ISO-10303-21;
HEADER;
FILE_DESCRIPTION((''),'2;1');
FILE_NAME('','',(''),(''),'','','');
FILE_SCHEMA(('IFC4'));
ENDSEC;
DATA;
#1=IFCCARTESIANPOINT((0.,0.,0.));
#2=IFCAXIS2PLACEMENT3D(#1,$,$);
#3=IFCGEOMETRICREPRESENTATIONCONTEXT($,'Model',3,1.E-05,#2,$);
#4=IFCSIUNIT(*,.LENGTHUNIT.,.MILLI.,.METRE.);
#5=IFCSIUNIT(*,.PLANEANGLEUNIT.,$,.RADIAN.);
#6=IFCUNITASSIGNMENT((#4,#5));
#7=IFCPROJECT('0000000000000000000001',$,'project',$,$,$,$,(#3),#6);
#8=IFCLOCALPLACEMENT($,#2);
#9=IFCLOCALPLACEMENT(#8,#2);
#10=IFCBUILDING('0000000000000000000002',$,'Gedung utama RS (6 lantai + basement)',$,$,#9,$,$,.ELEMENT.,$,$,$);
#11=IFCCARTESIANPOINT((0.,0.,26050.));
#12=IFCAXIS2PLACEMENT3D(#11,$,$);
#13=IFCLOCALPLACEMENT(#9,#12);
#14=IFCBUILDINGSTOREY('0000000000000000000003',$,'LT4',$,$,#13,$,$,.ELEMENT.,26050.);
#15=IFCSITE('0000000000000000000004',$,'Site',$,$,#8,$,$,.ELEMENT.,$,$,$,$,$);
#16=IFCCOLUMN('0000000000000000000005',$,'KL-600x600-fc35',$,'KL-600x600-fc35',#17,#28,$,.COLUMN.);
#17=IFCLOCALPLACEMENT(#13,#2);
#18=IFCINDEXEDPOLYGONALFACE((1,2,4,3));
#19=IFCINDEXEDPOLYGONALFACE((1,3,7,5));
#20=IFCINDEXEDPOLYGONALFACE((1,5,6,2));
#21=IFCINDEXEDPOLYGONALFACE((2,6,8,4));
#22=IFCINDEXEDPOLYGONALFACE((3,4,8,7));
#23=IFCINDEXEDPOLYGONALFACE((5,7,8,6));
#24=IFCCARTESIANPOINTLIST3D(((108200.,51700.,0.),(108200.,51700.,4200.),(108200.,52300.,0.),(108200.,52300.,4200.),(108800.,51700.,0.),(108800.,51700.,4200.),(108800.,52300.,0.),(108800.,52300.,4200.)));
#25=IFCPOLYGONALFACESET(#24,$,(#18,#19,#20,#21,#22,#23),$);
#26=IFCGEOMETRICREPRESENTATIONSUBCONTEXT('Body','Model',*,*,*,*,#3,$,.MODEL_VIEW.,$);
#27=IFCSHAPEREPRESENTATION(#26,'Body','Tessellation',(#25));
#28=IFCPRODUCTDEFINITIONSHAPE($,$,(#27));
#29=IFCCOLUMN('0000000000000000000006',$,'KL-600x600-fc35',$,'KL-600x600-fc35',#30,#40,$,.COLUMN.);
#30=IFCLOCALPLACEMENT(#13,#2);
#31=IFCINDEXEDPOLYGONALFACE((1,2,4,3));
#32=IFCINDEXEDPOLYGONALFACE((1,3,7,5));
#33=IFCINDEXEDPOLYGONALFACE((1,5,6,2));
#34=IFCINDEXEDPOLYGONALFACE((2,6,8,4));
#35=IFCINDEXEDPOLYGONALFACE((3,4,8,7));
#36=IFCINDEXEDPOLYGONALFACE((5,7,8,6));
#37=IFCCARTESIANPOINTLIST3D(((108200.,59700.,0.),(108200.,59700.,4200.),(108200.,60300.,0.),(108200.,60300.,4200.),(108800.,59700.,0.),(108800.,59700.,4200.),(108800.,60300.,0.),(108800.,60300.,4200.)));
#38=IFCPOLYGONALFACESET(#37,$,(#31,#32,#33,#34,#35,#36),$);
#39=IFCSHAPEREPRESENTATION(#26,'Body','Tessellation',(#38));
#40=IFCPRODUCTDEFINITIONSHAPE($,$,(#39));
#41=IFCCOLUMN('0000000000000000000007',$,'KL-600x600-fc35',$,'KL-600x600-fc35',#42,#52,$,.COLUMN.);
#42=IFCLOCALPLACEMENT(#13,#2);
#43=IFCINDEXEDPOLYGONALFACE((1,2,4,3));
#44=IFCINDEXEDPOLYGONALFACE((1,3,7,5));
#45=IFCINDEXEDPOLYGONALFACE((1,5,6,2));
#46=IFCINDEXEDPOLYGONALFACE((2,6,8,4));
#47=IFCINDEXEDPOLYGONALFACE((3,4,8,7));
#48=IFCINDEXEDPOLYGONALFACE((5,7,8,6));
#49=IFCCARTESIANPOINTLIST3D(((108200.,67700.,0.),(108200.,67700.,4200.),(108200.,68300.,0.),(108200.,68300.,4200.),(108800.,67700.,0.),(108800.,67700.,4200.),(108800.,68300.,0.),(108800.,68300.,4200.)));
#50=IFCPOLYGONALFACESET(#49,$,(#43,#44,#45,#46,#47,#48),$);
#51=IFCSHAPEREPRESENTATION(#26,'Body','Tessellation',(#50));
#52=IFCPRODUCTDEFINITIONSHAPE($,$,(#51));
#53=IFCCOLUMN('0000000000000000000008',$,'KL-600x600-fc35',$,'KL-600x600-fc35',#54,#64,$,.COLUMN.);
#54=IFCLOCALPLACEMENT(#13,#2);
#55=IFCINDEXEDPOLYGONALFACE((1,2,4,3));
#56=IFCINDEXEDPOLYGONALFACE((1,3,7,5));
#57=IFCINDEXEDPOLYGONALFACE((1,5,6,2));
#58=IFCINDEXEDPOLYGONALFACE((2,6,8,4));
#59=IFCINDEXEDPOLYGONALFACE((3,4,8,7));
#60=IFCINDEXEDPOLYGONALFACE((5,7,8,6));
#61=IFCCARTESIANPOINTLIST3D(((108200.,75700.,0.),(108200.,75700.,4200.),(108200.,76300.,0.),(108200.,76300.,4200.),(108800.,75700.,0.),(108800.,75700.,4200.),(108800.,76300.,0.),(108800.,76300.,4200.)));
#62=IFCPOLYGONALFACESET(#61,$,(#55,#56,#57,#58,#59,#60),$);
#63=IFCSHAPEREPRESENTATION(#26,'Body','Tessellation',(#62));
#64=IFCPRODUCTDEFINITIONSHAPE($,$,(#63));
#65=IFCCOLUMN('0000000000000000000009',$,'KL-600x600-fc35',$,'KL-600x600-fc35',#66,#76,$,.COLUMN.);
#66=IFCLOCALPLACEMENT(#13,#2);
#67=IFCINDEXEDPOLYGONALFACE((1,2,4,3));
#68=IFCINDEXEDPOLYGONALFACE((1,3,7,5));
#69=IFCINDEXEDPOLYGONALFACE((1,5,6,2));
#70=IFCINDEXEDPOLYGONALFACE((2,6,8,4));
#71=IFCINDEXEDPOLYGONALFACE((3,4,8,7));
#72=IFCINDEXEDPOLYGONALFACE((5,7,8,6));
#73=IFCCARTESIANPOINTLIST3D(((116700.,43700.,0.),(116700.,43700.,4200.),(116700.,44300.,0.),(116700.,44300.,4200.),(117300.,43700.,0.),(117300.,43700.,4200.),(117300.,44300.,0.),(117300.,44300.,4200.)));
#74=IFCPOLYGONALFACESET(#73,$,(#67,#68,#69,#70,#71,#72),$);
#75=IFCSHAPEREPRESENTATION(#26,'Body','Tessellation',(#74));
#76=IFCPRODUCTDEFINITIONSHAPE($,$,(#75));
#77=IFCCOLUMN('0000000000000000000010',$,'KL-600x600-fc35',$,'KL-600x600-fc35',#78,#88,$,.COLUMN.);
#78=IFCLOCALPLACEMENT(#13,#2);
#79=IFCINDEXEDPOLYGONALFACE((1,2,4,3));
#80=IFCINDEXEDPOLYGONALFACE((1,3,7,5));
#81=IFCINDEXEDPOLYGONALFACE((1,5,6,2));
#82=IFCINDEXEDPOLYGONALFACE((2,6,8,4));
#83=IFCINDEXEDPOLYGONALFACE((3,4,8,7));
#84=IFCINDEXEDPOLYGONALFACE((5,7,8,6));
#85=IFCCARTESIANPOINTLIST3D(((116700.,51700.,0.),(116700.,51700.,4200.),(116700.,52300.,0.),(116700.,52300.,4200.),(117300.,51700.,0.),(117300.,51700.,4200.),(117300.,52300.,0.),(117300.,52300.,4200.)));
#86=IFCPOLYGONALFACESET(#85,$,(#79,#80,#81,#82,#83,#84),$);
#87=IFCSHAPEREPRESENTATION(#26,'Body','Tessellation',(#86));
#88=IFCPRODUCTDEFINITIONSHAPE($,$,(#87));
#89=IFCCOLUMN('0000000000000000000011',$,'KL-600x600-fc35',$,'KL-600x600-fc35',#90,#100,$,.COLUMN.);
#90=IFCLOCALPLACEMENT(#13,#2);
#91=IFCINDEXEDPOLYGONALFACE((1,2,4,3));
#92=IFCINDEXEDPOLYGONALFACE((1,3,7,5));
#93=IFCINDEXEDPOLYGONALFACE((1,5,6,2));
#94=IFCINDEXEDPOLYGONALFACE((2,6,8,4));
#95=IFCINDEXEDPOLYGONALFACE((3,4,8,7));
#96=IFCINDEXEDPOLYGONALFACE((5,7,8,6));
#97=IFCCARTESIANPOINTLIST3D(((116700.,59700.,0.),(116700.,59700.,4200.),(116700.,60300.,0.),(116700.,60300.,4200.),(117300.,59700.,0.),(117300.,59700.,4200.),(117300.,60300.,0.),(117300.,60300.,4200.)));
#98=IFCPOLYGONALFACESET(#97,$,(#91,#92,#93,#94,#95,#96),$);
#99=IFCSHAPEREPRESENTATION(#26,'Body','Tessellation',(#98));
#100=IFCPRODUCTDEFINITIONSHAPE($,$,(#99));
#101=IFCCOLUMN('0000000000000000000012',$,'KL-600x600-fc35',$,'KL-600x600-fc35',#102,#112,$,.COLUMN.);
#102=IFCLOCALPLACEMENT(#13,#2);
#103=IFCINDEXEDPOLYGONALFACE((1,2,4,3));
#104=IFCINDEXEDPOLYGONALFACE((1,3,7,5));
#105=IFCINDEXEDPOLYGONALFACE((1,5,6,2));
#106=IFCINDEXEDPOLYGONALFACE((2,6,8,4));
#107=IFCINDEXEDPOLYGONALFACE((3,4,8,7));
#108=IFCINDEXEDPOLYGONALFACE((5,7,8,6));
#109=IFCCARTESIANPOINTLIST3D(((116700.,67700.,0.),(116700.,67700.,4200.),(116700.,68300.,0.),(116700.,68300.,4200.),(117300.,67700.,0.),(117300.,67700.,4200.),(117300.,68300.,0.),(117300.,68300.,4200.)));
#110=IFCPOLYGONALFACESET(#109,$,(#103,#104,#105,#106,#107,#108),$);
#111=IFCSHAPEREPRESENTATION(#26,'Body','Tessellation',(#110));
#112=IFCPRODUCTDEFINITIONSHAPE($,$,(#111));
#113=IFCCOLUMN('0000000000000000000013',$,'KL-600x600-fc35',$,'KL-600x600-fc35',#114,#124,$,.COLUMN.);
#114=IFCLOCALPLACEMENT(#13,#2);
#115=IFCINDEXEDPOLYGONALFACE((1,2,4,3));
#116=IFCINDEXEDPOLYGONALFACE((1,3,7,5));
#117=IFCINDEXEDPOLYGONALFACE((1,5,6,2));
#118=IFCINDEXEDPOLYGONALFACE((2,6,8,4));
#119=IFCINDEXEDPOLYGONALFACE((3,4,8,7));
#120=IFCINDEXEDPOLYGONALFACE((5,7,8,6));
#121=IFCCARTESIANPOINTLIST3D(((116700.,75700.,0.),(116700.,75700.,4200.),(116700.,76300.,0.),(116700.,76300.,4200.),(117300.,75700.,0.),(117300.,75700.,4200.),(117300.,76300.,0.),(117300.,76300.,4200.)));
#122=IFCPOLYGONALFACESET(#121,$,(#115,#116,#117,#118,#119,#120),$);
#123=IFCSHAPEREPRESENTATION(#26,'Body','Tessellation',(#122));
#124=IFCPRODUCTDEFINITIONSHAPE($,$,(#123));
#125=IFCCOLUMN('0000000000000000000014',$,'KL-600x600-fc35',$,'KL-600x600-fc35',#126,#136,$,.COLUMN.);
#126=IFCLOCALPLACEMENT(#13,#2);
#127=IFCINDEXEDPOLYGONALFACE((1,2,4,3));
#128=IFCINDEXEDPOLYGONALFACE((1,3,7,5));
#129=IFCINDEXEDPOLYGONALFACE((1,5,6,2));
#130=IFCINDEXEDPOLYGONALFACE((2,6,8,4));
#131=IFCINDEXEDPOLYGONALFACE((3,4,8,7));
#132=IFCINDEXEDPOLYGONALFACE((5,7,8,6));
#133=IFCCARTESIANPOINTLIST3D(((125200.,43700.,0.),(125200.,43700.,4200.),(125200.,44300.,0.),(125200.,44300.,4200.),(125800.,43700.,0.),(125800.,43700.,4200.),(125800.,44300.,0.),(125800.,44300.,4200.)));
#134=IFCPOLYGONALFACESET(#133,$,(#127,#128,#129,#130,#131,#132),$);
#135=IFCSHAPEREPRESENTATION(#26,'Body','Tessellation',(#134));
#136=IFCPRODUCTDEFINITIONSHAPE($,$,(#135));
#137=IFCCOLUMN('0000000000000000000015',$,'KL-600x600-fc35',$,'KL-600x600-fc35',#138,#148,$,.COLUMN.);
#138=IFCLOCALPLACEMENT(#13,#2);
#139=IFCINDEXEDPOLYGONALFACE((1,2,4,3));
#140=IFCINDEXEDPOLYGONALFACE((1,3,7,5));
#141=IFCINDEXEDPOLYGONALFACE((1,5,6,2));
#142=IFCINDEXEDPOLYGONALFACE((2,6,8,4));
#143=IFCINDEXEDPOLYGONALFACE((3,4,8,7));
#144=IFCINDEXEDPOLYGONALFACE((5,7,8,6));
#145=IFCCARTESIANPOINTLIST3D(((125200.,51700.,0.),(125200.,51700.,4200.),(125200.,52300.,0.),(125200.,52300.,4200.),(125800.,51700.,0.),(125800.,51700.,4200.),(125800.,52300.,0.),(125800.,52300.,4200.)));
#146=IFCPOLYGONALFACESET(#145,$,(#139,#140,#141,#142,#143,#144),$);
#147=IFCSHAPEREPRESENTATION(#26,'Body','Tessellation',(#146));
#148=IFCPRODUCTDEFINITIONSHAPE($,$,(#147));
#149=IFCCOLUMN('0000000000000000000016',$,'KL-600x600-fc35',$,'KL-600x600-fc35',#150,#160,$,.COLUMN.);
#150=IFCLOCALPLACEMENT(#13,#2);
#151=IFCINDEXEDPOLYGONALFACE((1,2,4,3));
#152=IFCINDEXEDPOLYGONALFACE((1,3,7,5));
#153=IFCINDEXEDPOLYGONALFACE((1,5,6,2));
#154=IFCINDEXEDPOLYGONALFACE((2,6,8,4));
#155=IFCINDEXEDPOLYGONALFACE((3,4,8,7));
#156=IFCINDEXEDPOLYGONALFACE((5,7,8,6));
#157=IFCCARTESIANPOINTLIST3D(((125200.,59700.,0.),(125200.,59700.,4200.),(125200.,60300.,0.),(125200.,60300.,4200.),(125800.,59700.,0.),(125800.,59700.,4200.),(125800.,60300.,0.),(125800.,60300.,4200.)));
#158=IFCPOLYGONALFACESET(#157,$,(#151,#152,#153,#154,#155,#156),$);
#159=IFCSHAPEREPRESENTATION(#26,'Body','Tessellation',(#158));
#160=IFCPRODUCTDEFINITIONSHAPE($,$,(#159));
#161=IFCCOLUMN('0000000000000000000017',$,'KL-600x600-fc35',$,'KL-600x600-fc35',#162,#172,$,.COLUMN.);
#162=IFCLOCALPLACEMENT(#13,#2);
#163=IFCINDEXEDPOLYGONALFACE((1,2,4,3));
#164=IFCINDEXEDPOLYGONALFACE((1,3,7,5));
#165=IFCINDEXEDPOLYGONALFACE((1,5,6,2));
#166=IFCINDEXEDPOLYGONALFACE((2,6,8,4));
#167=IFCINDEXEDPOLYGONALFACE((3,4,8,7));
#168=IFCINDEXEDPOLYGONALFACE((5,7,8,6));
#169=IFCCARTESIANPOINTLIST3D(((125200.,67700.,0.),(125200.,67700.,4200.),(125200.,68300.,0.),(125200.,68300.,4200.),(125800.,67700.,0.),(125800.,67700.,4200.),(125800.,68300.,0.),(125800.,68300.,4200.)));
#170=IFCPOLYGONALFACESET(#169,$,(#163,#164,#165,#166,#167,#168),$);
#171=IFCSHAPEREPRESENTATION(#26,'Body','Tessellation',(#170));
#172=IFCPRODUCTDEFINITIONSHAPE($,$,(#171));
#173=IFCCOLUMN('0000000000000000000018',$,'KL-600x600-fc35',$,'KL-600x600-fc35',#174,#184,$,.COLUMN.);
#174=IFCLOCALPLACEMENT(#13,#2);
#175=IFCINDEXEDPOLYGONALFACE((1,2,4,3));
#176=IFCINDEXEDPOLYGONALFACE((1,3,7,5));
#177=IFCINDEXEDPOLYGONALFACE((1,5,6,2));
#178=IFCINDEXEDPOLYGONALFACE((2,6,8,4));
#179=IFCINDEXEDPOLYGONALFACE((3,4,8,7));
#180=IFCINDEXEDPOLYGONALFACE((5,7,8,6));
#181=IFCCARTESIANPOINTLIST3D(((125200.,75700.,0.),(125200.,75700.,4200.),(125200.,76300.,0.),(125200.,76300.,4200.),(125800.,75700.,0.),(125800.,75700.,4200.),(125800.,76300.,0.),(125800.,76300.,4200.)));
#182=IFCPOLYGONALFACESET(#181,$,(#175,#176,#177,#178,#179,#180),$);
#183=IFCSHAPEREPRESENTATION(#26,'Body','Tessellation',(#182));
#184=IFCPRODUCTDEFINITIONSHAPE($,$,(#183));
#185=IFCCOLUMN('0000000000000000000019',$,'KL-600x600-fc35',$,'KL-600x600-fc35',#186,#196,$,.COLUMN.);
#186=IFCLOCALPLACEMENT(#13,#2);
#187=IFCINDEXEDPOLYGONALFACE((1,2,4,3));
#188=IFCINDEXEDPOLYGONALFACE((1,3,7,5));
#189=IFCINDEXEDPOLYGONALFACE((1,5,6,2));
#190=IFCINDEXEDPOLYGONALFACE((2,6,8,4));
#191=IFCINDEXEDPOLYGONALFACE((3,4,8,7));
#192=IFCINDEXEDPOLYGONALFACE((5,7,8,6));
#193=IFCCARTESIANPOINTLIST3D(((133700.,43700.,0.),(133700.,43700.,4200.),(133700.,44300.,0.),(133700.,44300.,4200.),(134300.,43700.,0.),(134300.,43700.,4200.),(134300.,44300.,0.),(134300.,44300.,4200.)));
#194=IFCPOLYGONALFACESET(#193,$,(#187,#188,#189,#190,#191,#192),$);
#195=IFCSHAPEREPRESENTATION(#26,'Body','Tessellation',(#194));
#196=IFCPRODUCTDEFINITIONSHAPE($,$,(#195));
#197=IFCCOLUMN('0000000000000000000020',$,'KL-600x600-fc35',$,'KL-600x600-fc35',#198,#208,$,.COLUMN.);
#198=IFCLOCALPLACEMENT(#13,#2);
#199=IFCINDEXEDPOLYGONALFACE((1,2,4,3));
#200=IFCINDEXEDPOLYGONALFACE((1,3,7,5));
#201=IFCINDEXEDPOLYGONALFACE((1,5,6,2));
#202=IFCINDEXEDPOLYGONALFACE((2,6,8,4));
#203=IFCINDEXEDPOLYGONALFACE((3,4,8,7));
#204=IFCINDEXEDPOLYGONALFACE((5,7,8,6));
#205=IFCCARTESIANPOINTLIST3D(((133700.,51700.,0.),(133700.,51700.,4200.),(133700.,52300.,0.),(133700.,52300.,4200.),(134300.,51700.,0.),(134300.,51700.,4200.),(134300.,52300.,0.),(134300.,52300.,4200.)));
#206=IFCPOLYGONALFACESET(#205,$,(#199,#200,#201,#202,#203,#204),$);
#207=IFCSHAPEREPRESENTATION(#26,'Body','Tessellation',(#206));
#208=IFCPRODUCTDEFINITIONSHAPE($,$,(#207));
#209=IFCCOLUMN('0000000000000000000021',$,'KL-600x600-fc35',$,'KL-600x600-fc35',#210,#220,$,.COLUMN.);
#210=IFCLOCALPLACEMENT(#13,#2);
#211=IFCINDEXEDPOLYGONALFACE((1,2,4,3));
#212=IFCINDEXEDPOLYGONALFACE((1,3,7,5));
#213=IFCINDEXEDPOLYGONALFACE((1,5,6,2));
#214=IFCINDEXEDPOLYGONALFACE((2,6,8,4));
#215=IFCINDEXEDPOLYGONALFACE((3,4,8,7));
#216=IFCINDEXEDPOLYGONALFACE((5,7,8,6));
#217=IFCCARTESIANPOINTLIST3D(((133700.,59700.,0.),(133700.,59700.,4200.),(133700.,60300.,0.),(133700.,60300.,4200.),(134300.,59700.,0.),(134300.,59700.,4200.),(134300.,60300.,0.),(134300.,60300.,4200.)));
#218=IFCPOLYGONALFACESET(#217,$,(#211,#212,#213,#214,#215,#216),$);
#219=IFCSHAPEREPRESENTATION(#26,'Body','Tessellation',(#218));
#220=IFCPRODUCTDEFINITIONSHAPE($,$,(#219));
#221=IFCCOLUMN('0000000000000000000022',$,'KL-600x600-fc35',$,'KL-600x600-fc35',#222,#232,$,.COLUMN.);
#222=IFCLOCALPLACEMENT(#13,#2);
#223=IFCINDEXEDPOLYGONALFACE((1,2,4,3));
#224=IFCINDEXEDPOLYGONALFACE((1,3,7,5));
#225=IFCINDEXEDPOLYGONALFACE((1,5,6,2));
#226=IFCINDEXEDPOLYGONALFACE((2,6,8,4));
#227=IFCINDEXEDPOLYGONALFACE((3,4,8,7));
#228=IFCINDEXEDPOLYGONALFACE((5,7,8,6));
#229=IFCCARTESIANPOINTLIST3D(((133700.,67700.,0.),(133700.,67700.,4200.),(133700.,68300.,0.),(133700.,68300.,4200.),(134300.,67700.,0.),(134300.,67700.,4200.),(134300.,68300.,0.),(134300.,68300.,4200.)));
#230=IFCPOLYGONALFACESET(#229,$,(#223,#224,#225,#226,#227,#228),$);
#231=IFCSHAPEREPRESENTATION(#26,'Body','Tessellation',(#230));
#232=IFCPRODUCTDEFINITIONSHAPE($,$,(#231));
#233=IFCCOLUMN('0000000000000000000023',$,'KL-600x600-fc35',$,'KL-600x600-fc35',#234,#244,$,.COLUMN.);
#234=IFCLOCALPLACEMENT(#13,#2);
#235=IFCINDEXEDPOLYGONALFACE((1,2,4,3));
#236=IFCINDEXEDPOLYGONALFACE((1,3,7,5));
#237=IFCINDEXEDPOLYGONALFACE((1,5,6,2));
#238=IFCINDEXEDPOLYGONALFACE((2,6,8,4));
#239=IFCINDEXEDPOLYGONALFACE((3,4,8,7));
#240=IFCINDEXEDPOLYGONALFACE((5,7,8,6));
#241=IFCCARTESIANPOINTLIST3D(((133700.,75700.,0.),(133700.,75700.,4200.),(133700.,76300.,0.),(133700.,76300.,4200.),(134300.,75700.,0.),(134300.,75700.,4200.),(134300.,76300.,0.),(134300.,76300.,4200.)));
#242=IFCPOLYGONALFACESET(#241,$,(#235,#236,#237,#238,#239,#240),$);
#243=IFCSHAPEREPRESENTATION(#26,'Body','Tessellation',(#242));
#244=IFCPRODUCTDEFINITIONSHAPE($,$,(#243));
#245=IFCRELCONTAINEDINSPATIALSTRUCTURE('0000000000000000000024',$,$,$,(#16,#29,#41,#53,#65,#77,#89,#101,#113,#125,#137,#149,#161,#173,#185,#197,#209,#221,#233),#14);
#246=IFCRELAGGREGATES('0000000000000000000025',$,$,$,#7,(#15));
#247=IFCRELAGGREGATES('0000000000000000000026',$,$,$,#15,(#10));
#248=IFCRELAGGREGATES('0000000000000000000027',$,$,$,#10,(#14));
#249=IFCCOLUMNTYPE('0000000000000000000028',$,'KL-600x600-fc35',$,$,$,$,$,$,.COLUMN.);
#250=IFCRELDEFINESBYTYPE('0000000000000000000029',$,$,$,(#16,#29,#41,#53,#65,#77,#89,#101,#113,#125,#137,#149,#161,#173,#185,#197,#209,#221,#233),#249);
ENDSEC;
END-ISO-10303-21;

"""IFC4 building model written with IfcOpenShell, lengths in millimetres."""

from ifc_helpers import new_model, si_unit, frame, origin, origin_2d, place, context, subcontext, project, spatial, rectangle, extrude, material_profile, profile_set, profile_usage, type_object, element, save


model = new_model("IFC4")

# Units and contexts
model_context = context("Model", 3, precision=1e-05, world=origin())
body_context = subcontext(model_context, "Body", "Model", "MODEL_VIEW")
ifc_project = project(units=[si_unit("LENGTHUNIT", "METRE", prefix="MILLI"), si_unit("PLANEANGLEUNIT", "RADIAN")], contexts=[model_context])

# Site, building, storey
site_placement = place(None, origin())
site = spatial("IfcSite", under=ifc_project, at=site_placement, Name="Site", CompositionType="ELEMENT")
building_placement = place(site_placement, origin())
building = spatial("IfcBuilding", under=site, at=building_placement, Name="Gedung utama RS (6 lantai + basement)", CompositionType="ELEMENT")
storey_placement = place(building_placement, frame((0.0, 0.0, 26050.0)))
storey = spatial("IfcBuildingStorey", under=building, at=storey_placement, Name="LT4", CompositionType="ELEMENT", Elevation=26050.0)

# Columns
ifc_material_profile_1 = material_profile(None, rectangle(XDim=600.0, YDim=600.0, at=origin_2d()), Name="KL-600x600-fc35")
ifc_profile_set_1 = profile_set([ifc_material_profile_1], Name="KL-600x600-fc35")
ifc_profile_usage_1 = profile_usage(ifc_profile_set_1, cardinal=5)
column_type = type_object("IfcColumnType", Name="KL-600x600-fc35", PredefinedType="COLUMN", material=ifc_profile_set_1)
for number, where, z_axis, x_axis, name in (
    (1, (108500.0, 52000.0, 0.0), (0.0, 0.0, 1.0), (1.0, 0.0, 0.0), "KL-600x600-fc35"),
    (2, (108500.0, 60000.0, 0.0), (0.0, 0.0, 1.0), (1.0, 0.0, 0.0), "KL-600x600-fc35"),
    (3, (108500.0, 68000.0, 0.0), (0.0, 0.0, 1.0), (1.0, 0.0, 0.0), "KL-600x600-fc35"),
    (4, (108500.0, 76000.0, 0.0), (0.0, 0.0, 1.0), (1.0, 0.0, 0.0), "KL-600x600-fc35"),
    (5, (117000.0, 44000.0, 0.0), (0.0, 0.0, 1.0), (1.0, 0.0, 0.0), "KL-600x600-fc35"),
    (6, (117000.0, 52000.0, 0.0), (0.0, 0.0, 1.0), (1.0, 0.0, 0.0), "KL-600x600-fc35"),
    (7, (117000.0, 60000.0, 0.0), (0.0, 0.0, 1.0), (1.0, 0.0, 0.0), "KL-600x600-fc35"),
    (8, (117000.0, 68000.0, 0.0), (0.0, 0.0, 1.0), (1.0, 0.0, 0.0), "KL-600x600-fc35"),
    (9, (117000.0, 76000.0, 0.0), (0.0, 0.0, 1.0), (1.0, 0.0, 0.0), "KL-600x600-fc35"),
    (10, (125500.0, 44000.0, 0.0), (0.0, 0.0, 1.0), (1.0, 0.0, 0.0), "KL-600x600-fc35"),
    (11, (125500.0, 52000.0, 0.0), (0.0, 0.0, 1.0), (1.0, 0.0, 0.0), "KL-600x600-fc35"),
    (12, (125500.0, 60000.0, 0.0), (0.0, 0.0, 1.0), (1.0, 0.0, 0.0), "KL-600x600-fc35"),
    (13, (125500.0, 68000.0, 0.0), (0.0, 0.0, 1.0), (1.0, 0.0, 0.0), "KL-600x600-fc35"),
    (14, (125500.0, 76000.0, 0.0), (0.0, 0.0, 1.0), (1.0, 0.0, 0.0), "KL-600x600-fc35"),
    (15, (134000.0, 44000.0, 0.0), (0.0, 0.0, 1.0), (1.0, 0.0, 0.0), "KL-600x600-fc35"),
    (16, (134000.0, 52000.0, 0.0), (0.0, 0.0, 1.0), (1.0, 0.0, 0.0), "KL-600x600-fc35"),
    (17, (134000.0, 60000.0, 0.0), (0.0, 0.0, 1.0), (1.0, 0.0, 0.0), "KL-600x600-fc35"),
    (18, (134000.0, 68000.0, 0.0), (0.0, 0.0, 1.0), (1.0, 0.0, 0.0), "KL-600x600-fc35"),
    (19, (134000.0, 76000.0, 0.0), (0.0, 0.0, 1.0), (1.0, 0.0, 0.0), "KL-600x600-fc35"),
):
    element("IfcColumn", number, at=place(storey_placement, frame(where, z_axis=z_axis, x_axis=x_axis)), inside=storey, type_object=column_type, material=ifc_profile_usage_1, Name=name, ObjectType="KL-600x600-fc35", PredefinedType="COLUMN", context=body_context, shape_type="SweptSolid", body=[
        extrude(rectangle(XDim=600.0, YDim=600.0, at=origin_2d()), origin(), (0.0, 0.0, 1.0), 4200.0),
    ])

save(model, "model.ifc")
